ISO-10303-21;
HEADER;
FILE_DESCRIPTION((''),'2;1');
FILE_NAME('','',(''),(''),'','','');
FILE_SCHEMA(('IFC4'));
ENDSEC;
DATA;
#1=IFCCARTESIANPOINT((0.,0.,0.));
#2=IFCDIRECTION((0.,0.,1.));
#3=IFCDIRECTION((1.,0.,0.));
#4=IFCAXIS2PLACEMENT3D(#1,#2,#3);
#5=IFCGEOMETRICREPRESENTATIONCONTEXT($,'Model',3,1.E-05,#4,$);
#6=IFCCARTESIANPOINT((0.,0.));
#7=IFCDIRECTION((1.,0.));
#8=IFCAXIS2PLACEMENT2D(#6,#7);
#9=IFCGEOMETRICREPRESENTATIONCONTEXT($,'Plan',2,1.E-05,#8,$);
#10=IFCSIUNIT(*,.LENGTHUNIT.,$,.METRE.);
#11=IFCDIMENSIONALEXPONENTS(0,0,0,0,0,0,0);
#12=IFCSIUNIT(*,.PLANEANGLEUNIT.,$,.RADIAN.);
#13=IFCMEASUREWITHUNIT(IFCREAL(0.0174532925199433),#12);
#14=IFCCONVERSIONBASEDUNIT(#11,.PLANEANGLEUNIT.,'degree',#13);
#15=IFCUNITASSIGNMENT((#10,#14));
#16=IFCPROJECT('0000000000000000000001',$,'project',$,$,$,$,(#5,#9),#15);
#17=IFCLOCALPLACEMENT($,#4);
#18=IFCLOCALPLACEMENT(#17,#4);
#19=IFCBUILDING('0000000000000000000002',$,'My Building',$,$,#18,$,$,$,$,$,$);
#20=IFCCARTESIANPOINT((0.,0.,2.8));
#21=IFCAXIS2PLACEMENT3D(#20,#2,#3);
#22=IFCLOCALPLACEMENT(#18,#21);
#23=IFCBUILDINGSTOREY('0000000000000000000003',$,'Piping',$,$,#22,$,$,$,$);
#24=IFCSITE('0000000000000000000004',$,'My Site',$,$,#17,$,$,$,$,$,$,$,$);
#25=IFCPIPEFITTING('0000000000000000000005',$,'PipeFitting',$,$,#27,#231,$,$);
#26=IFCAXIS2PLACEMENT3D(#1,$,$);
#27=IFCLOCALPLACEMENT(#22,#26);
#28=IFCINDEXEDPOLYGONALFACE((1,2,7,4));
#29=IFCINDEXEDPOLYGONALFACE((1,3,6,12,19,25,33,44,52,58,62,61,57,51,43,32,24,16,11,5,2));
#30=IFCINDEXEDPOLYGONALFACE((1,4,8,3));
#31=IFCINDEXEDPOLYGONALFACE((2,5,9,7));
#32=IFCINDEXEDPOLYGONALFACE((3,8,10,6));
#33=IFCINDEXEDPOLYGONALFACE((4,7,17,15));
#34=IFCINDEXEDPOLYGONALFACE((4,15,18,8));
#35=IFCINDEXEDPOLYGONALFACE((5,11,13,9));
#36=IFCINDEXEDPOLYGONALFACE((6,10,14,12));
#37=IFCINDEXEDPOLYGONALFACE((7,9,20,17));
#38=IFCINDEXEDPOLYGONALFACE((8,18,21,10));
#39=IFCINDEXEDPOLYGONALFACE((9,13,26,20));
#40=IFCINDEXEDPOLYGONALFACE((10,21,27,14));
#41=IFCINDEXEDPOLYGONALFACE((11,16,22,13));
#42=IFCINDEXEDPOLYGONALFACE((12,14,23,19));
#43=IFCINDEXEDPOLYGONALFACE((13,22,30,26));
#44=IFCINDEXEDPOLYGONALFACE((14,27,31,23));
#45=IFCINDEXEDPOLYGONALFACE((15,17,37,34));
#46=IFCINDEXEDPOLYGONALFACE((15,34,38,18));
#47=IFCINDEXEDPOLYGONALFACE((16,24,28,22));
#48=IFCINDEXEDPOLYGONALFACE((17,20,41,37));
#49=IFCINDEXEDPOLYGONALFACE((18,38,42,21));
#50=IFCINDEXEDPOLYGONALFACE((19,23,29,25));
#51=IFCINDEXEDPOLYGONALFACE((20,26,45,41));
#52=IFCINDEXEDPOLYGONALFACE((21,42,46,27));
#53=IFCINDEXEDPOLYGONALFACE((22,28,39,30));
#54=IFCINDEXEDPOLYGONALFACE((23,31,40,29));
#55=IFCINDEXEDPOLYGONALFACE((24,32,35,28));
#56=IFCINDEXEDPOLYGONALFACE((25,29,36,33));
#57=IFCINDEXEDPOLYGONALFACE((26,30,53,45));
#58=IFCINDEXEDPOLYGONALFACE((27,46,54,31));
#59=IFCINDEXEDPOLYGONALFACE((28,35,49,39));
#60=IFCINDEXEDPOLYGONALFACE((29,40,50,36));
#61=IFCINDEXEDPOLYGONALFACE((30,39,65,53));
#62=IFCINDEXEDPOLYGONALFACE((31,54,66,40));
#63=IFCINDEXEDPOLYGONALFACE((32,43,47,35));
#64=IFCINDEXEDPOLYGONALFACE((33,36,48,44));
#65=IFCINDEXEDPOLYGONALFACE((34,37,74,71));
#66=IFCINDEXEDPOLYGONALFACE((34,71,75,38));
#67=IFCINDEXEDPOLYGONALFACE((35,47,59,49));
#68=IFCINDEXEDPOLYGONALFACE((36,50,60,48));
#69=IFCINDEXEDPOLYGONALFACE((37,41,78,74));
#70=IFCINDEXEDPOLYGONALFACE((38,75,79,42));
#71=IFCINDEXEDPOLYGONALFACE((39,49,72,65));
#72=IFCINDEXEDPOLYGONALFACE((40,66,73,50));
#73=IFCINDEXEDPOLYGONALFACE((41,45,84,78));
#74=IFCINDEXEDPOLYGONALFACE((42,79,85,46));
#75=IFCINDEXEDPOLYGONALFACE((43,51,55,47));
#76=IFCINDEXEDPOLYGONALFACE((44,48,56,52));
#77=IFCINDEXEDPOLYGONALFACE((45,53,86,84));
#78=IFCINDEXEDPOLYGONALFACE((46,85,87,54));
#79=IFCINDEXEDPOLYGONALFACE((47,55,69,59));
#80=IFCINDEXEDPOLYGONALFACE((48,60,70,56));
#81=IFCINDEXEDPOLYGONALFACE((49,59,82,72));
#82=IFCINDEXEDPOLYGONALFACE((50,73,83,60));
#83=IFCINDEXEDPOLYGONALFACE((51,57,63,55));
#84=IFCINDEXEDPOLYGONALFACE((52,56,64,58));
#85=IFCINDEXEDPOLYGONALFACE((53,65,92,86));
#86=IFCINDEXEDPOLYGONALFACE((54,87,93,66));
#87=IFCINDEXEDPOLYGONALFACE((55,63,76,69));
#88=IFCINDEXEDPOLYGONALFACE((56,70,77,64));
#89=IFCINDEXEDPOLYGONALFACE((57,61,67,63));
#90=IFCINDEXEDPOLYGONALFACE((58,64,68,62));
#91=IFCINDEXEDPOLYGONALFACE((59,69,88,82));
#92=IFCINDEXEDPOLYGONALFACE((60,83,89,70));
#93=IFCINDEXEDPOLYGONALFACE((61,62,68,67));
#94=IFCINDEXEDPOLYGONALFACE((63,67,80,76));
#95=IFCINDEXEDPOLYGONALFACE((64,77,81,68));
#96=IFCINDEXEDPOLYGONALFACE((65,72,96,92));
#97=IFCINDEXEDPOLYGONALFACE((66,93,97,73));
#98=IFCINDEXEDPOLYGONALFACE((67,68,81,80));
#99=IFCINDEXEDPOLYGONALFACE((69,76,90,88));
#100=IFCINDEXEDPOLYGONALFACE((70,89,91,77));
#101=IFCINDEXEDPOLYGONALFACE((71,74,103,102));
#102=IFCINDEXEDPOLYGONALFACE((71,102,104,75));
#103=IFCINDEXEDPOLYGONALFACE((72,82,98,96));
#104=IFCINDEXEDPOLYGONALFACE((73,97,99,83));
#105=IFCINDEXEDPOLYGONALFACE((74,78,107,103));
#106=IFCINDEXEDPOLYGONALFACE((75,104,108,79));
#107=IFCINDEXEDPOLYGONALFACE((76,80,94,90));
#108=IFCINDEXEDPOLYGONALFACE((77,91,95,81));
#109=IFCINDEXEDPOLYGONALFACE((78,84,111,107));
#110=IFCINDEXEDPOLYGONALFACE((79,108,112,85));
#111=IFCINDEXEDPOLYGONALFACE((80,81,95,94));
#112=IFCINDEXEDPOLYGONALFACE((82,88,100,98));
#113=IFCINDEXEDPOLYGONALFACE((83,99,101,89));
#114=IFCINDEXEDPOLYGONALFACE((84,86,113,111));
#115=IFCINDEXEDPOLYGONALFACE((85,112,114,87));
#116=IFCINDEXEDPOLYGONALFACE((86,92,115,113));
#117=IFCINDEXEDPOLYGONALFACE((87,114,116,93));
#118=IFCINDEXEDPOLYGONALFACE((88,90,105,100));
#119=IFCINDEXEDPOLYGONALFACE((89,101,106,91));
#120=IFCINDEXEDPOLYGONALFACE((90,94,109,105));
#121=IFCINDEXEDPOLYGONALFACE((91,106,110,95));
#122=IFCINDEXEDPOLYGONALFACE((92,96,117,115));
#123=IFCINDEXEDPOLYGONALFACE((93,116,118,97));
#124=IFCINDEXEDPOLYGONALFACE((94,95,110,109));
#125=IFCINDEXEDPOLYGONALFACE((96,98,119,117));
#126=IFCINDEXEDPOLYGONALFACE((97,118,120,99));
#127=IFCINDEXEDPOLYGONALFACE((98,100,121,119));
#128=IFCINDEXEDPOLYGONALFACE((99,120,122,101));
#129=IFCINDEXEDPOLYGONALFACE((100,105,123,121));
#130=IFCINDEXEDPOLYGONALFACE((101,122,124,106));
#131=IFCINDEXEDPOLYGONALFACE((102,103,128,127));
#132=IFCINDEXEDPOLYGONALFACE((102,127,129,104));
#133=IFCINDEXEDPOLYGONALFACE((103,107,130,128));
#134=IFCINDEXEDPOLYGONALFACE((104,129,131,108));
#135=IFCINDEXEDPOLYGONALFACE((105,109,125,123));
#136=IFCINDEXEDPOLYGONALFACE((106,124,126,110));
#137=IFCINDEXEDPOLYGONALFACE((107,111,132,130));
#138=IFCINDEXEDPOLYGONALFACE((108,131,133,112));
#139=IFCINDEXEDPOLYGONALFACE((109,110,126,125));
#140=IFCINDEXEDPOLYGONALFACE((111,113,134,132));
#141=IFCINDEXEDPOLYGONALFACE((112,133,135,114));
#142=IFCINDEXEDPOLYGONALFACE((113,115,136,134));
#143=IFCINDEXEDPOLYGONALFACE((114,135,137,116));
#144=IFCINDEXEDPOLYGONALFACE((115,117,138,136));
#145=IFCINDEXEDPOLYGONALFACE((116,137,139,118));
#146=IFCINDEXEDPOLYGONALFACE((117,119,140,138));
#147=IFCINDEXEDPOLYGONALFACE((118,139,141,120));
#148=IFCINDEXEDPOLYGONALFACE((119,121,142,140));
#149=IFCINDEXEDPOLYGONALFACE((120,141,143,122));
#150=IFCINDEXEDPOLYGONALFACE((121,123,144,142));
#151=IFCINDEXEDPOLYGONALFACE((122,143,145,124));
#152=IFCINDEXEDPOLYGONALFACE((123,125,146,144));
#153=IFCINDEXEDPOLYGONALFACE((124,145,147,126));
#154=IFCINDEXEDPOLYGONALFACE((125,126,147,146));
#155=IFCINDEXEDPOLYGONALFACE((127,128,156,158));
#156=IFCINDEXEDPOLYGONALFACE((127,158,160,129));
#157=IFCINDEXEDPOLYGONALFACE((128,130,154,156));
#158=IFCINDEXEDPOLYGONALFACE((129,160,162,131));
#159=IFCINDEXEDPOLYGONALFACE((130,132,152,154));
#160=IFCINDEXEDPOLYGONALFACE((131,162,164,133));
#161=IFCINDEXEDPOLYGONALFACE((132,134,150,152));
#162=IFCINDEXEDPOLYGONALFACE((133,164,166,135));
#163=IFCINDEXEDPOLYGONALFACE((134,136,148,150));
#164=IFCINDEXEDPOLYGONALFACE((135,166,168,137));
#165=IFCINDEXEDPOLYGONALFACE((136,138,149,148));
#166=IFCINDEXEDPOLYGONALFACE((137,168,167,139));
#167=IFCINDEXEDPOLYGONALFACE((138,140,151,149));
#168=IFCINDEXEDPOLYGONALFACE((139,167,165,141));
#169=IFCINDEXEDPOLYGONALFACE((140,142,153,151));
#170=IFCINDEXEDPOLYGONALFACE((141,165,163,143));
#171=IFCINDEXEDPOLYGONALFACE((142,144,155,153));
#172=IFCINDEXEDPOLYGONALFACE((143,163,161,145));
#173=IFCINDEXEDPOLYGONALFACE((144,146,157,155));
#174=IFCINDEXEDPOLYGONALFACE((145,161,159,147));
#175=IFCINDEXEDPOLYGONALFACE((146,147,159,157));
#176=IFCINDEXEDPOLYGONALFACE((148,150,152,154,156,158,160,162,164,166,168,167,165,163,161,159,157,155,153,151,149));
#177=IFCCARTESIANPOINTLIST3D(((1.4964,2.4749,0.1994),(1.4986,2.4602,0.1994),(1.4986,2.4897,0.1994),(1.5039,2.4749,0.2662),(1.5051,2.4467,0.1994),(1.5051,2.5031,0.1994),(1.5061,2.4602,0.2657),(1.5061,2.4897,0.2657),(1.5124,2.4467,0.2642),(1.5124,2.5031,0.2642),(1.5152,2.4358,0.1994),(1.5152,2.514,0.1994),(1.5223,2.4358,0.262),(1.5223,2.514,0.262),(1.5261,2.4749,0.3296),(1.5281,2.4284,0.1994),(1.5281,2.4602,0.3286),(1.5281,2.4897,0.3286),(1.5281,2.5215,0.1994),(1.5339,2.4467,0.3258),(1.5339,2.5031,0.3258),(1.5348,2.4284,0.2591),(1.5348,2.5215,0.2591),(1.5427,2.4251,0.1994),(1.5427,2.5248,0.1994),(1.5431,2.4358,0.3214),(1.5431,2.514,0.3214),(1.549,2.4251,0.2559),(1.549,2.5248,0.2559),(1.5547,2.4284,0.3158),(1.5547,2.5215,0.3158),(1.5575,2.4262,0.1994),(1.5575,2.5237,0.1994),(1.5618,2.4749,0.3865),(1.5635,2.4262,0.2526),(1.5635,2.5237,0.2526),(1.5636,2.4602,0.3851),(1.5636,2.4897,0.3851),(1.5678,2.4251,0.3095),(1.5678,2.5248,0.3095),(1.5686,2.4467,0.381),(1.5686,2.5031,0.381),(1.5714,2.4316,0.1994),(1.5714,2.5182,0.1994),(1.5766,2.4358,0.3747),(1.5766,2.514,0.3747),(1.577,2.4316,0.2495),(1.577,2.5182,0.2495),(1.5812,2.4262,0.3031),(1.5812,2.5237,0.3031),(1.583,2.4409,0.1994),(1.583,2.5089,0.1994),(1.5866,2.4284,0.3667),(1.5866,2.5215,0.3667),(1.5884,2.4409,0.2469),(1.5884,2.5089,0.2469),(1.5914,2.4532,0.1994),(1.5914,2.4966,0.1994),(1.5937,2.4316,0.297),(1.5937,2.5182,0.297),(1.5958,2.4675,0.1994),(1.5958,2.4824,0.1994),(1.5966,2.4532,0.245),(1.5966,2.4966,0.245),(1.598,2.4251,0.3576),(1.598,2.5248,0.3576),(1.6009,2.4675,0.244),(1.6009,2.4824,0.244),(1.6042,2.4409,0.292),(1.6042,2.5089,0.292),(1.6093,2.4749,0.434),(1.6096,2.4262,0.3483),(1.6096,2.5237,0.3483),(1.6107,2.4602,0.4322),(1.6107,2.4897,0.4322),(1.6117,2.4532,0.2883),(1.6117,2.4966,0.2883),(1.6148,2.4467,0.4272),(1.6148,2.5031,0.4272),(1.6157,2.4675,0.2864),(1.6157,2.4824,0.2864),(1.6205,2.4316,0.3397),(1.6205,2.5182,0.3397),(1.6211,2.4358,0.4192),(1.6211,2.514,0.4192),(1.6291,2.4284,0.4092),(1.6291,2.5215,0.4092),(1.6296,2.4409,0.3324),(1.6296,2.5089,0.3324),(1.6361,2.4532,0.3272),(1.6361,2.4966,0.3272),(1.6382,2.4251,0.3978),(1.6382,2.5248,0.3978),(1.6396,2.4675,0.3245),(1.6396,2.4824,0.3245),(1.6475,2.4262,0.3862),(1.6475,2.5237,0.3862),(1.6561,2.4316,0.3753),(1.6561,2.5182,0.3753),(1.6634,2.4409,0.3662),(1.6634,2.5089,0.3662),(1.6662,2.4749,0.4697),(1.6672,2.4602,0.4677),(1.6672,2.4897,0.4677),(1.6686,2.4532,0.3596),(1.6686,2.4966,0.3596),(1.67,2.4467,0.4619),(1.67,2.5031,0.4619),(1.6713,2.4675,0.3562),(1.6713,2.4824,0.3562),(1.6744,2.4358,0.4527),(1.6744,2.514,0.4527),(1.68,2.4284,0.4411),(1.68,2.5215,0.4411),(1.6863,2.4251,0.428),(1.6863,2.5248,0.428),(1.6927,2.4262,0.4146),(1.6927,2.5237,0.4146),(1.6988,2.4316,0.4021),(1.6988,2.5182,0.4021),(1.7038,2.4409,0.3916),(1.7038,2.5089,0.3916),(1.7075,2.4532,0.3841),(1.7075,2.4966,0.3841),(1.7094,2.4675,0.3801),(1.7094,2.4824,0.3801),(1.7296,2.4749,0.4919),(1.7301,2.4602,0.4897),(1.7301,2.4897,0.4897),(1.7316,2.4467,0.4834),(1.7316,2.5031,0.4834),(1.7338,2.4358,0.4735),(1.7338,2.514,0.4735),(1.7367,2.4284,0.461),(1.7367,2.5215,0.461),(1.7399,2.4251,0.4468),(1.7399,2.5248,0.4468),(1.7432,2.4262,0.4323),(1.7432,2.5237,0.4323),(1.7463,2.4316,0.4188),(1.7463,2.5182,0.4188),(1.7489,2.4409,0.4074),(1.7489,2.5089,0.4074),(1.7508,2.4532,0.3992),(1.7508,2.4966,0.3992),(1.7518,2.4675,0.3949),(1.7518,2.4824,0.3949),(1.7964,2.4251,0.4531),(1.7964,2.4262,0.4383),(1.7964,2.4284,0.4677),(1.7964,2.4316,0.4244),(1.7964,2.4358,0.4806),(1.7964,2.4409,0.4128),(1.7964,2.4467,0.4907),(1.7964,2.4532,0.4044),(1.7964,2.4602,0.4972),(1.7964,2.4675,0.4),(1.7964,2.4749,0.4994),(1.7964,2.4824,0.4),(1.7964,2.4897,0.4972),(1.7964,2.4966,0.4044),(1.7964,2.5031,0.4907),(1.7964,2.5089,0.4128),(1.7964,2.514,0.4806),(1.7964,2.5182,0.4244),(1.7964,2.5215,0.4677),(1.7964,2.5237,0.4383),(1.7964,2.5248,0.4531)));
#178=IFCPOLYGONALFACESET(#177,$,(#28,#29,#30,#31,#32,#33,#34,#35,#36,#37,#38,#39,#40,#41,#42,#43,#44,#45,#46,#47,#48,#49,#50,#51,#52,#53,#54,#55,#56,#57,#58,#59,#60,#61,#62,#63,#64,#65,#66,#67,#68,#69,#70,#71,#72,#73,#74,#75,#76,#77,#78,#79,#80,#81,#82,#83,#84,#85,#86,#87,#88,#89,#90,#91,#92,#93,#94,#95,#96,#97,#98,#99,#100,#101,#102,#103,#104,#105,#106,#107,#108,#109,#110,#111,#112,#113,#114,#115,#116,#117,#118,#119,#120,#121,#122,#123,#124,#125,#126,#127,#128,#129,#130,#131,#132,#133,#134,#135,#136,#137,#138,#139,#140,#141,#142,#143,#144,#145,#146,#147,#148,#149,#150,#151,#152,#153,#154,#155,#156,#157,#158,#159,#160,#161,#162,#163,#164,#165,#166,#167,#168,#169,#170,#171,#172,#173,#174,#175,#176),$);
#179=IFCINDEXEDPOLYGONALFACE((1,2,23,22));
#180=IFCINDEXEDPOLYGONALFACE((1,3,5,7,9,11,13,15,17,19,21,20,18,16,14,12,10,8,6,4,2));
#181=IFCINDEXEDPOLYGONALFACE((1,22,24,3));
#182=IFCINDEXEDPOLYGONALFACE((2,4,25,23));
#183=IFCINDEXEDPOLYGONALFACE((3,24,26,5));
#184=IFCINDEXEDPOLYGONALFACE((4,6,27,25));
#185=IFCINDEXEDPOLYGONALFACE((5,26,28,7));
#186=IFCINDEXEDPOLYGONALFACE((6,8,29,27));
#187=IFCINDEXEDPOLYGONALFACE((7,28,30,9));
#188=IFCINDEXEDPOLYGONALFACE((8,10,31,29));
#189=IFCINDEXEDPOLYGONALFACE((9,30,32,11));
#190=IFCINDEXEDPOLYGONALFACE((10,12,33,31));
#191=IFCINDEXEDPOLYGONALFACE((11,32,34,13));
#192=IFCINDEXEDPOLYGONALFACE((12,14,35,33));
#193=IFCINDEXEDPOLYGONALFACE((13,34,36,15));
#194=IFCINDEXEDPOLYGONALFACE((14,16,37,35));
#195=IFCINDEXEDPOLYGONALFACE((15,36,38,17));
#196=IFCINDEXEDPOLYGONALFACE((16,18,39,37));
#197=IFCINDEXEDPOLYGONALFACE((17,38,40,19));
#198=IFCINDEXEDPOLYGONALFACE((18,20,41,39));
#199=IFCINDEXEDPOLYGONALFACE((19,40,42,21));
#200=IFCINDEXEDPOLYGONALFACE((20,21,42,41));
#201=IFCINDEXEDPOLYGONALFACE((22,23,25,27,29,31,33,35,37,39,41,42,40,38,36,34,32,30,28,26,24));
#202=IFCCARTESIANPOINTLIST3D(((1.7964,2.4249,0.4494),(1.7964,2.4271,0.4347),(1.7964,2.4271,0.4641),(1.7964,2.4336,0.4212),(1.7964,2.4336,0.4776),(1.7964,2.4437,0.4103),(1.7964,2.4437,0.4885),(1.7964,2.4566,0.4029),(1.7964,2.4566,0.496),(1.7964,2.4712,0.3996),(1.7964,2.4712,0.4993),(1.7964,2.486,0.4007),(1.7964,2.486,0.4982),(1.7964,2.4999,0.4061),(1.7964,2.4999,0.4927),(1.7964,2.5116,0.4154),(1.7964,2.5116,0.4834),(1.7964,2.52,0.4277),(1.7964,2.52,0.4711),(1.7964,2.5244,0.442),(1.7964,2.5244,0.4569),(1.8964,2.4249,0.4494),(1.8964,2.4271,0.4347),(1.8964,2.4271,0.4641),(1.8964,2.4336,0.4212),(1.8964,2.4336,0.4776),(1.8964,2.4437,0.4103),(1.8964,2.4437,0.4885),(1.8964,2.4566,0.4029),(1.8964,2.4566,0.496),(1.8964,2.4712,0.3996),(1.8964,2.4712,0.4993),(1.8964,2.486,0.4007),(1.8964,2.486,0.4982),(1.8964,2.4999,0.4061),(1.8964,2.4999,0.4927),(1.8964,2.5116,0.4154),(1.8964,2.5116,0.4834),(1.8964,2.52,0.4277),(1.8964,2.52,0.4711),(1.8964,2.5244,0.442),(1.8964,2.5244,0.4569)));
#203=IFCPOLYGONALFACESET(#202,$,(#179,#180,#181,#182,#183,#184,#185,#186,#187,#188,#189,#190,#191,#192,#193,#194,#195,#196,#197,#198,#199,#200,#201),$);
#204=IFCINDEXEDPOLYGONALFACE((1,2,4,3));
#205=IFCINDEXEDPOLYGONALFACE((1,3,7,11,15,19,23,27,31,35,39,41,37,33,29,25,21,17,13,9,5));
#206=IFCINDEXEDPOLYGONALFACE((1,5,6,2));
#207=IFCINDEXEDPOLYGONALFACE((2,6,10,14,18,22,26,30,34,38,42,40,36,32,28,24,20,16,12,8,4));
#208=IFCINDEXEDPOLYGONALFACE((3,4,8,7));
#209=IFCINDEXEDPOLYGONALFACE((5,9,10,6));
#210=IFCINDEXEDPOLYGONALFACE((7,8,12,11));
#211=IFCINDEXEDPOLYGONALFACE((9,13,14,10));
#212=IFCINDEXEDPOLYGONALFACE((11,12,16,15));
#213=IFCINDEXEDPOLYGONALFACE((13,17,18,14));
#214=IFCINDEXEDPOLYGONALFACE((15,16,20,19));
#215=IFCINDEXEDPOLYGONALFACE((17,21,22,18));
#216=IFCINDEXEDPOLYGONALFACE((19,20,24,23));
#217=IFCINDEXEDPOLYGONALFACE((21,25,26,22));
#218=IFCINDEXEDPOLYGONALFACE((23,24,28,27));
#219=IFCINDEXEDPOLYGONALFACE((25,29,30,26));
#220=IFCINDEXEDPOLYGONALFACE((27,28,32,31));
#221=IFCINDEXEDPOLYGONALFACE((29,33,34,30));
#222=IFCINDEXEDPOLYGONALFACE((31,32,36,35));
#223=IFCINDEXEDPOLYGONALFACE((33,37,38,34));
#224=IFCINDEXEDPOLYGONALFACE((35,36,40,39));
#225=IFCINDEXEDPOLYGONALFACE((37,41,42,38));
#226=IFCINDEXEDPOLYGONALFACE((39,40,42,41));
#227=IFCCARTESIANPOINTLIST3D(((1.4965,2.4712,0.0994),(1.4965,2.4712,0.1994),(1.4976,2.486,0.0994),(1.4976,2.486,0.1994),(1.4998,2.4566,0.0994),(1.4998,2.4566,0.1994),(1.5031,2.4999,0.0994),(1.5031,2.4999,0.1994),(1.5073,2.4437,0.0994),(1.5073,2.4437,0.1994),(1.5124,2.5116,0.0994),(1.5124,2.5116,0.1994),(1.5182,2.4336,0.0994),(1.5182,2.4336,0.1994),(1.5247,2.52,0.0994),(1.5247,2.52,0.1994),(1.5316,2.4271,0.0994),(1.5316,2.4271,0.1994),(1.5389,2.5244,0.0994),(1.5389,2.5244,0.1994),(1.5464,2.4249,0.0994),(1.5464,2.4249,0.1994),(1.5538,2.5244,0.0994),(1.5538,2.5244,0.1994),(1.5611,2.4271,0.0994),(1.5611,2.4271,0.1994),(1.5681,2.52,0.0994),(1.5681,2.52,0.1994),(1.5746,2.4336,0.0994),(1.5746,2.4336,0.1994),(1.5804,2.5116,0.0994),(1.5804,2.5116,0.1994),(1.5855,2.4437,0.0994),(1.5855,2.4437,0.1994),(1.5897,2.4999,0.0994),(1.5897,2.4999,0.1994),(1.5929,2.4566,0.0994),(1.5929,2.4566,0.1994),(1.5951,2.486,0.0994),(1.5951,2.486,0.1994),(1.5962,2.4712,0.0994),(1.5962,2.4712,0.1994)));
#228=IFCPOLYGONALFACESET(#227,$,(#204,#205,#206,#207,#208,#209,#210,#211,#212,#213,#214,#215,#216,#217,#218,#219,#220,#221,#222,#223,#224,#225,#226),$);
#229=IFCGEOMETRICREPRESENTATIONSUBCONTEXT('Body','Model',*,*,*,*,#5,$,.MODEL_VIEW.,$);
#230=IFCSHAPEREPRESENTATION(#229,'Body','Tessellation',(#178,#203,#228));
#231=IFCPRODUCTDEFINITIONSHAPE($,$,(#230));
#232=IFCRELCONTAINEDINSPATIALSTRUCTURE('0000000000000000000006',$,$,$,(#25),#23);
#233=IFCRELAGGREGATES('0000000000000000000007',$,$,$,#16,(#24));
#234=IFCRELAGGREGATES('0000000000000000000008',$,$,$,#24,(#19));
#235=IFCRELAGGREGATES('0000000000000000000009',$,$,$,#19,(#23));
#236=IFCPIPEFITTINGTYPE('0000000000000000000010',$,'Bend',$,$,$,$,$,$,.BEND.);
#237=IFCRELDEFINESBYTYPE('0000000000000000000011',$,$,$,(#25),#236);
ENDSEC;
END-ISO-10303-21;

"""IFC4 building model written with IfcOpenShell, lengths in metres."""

from ifc_helpers import new_model, entity, si_unit, converted_unit, frame, origin_with_axes, origin_2d_with_axis, place, context, subcontext, project, spatial, circle, extrude, source, transform, mapped, type_object, type_shapes, element, save


model = new_model("IFC4")

# Units and contexts
model_context = context("Model", 3, precision=1e-05, world=origin_with_axes())
plan_context = context("Plan", 2, precision=1e-05, world=origin_2d_with_axis())
body_context = subcontext(model_context, "Body", "Model", "MODEL_VIEW")
ifc_project = project(units=[si_unit("LENGTHUNIT", "METRE"), converted_unit("PLANEANGLEUNIT", "degree", entity("IfcReal", 0.0174532925199433), si_unit("PLANEANGLEUNIT", "RADIAN"), dimensions=[0, 0, 0, 0, 0, 0, 0])], contexts=[model_context, plan_context])

# Site, building, storey
site_placement = place(None, origin_with_axes())
site = spatial("IfcSite", under=ifc_project, at=site_placement, Name="My Site")
building_placement = place(site_placement, origin_with_axes())
building = spatial("IfcBuilding", under=site, at=building_placement, Name="My Building")
storey_placement = place(building_placement, frame((0.0, 0.0, 2.8), z_axis=(0.0, 0.0, 1.0), x_axis=(1.0, 0.0, 0.0)))
storey = spatial("IfcBuildingStorey", under=building, at=storey_placement, Name="Piping")

# Pipe fitting
pipe_fitting_type_1 = type_object("IfcPipeFittingType", Name="Bend", PredefinedType="BEND")
shared_shape_1 = source(origin_with_axes(), body_context, "Body", "SolidModel", [
    entity("IfcSweptDiskSolid", entity("IfcIndexedPolyCurve", entity("IfcCartesianPointList3D", [[0.0, 0.0, 0.1], [0.0, -0.0732, 0.2768], [0.0, -0.25, 0.35]]), [entity("IfcArcIndex", [1, 2, 3])]), 0.05),
    extrude(circle(Radius=0.05), origin_with_axes(), (0.0, 0.0, 1.0), 0.1),
    extrude(circle(Radius=0.05), frame((0.0, -0.25, 0.35), z_axis=(0.0, -1.0, 0.0), x_axis=(1.0, 0.0, 0.0)), (0.0, 0.0, 1.0), 0.1),
])
type_shapes(pipe_fitting_type_1, [shared_shape_1])
for number, where, z_axis, x_axis, name in (
    (1, (1.8964, 2.4749, 0.4494), (-1.0, 0.0, 0.0), (0.0, -1.0, 0.0), "PipeFitting"),
):
    element("IfcPipeFitting", number, at=place(storey_placement, frame(where, z_axis=z_axis, x_axis=x_axis)), inside=storey, type_object=pipe_fitting_type_1, Name=name, context=body_context, shape_type="MappedRepresentation", body=[
        mapped(shared_shape_1, transform((0.0, 0.0, 0.0), x_axis=(1.0, 0.0, 0.0), y_axis=(0.0, 1.0, 0.0), z_axis=(0.0, 0.0, 1.0), scale=1.0)),
    ])

save(model, "model.ifc")
